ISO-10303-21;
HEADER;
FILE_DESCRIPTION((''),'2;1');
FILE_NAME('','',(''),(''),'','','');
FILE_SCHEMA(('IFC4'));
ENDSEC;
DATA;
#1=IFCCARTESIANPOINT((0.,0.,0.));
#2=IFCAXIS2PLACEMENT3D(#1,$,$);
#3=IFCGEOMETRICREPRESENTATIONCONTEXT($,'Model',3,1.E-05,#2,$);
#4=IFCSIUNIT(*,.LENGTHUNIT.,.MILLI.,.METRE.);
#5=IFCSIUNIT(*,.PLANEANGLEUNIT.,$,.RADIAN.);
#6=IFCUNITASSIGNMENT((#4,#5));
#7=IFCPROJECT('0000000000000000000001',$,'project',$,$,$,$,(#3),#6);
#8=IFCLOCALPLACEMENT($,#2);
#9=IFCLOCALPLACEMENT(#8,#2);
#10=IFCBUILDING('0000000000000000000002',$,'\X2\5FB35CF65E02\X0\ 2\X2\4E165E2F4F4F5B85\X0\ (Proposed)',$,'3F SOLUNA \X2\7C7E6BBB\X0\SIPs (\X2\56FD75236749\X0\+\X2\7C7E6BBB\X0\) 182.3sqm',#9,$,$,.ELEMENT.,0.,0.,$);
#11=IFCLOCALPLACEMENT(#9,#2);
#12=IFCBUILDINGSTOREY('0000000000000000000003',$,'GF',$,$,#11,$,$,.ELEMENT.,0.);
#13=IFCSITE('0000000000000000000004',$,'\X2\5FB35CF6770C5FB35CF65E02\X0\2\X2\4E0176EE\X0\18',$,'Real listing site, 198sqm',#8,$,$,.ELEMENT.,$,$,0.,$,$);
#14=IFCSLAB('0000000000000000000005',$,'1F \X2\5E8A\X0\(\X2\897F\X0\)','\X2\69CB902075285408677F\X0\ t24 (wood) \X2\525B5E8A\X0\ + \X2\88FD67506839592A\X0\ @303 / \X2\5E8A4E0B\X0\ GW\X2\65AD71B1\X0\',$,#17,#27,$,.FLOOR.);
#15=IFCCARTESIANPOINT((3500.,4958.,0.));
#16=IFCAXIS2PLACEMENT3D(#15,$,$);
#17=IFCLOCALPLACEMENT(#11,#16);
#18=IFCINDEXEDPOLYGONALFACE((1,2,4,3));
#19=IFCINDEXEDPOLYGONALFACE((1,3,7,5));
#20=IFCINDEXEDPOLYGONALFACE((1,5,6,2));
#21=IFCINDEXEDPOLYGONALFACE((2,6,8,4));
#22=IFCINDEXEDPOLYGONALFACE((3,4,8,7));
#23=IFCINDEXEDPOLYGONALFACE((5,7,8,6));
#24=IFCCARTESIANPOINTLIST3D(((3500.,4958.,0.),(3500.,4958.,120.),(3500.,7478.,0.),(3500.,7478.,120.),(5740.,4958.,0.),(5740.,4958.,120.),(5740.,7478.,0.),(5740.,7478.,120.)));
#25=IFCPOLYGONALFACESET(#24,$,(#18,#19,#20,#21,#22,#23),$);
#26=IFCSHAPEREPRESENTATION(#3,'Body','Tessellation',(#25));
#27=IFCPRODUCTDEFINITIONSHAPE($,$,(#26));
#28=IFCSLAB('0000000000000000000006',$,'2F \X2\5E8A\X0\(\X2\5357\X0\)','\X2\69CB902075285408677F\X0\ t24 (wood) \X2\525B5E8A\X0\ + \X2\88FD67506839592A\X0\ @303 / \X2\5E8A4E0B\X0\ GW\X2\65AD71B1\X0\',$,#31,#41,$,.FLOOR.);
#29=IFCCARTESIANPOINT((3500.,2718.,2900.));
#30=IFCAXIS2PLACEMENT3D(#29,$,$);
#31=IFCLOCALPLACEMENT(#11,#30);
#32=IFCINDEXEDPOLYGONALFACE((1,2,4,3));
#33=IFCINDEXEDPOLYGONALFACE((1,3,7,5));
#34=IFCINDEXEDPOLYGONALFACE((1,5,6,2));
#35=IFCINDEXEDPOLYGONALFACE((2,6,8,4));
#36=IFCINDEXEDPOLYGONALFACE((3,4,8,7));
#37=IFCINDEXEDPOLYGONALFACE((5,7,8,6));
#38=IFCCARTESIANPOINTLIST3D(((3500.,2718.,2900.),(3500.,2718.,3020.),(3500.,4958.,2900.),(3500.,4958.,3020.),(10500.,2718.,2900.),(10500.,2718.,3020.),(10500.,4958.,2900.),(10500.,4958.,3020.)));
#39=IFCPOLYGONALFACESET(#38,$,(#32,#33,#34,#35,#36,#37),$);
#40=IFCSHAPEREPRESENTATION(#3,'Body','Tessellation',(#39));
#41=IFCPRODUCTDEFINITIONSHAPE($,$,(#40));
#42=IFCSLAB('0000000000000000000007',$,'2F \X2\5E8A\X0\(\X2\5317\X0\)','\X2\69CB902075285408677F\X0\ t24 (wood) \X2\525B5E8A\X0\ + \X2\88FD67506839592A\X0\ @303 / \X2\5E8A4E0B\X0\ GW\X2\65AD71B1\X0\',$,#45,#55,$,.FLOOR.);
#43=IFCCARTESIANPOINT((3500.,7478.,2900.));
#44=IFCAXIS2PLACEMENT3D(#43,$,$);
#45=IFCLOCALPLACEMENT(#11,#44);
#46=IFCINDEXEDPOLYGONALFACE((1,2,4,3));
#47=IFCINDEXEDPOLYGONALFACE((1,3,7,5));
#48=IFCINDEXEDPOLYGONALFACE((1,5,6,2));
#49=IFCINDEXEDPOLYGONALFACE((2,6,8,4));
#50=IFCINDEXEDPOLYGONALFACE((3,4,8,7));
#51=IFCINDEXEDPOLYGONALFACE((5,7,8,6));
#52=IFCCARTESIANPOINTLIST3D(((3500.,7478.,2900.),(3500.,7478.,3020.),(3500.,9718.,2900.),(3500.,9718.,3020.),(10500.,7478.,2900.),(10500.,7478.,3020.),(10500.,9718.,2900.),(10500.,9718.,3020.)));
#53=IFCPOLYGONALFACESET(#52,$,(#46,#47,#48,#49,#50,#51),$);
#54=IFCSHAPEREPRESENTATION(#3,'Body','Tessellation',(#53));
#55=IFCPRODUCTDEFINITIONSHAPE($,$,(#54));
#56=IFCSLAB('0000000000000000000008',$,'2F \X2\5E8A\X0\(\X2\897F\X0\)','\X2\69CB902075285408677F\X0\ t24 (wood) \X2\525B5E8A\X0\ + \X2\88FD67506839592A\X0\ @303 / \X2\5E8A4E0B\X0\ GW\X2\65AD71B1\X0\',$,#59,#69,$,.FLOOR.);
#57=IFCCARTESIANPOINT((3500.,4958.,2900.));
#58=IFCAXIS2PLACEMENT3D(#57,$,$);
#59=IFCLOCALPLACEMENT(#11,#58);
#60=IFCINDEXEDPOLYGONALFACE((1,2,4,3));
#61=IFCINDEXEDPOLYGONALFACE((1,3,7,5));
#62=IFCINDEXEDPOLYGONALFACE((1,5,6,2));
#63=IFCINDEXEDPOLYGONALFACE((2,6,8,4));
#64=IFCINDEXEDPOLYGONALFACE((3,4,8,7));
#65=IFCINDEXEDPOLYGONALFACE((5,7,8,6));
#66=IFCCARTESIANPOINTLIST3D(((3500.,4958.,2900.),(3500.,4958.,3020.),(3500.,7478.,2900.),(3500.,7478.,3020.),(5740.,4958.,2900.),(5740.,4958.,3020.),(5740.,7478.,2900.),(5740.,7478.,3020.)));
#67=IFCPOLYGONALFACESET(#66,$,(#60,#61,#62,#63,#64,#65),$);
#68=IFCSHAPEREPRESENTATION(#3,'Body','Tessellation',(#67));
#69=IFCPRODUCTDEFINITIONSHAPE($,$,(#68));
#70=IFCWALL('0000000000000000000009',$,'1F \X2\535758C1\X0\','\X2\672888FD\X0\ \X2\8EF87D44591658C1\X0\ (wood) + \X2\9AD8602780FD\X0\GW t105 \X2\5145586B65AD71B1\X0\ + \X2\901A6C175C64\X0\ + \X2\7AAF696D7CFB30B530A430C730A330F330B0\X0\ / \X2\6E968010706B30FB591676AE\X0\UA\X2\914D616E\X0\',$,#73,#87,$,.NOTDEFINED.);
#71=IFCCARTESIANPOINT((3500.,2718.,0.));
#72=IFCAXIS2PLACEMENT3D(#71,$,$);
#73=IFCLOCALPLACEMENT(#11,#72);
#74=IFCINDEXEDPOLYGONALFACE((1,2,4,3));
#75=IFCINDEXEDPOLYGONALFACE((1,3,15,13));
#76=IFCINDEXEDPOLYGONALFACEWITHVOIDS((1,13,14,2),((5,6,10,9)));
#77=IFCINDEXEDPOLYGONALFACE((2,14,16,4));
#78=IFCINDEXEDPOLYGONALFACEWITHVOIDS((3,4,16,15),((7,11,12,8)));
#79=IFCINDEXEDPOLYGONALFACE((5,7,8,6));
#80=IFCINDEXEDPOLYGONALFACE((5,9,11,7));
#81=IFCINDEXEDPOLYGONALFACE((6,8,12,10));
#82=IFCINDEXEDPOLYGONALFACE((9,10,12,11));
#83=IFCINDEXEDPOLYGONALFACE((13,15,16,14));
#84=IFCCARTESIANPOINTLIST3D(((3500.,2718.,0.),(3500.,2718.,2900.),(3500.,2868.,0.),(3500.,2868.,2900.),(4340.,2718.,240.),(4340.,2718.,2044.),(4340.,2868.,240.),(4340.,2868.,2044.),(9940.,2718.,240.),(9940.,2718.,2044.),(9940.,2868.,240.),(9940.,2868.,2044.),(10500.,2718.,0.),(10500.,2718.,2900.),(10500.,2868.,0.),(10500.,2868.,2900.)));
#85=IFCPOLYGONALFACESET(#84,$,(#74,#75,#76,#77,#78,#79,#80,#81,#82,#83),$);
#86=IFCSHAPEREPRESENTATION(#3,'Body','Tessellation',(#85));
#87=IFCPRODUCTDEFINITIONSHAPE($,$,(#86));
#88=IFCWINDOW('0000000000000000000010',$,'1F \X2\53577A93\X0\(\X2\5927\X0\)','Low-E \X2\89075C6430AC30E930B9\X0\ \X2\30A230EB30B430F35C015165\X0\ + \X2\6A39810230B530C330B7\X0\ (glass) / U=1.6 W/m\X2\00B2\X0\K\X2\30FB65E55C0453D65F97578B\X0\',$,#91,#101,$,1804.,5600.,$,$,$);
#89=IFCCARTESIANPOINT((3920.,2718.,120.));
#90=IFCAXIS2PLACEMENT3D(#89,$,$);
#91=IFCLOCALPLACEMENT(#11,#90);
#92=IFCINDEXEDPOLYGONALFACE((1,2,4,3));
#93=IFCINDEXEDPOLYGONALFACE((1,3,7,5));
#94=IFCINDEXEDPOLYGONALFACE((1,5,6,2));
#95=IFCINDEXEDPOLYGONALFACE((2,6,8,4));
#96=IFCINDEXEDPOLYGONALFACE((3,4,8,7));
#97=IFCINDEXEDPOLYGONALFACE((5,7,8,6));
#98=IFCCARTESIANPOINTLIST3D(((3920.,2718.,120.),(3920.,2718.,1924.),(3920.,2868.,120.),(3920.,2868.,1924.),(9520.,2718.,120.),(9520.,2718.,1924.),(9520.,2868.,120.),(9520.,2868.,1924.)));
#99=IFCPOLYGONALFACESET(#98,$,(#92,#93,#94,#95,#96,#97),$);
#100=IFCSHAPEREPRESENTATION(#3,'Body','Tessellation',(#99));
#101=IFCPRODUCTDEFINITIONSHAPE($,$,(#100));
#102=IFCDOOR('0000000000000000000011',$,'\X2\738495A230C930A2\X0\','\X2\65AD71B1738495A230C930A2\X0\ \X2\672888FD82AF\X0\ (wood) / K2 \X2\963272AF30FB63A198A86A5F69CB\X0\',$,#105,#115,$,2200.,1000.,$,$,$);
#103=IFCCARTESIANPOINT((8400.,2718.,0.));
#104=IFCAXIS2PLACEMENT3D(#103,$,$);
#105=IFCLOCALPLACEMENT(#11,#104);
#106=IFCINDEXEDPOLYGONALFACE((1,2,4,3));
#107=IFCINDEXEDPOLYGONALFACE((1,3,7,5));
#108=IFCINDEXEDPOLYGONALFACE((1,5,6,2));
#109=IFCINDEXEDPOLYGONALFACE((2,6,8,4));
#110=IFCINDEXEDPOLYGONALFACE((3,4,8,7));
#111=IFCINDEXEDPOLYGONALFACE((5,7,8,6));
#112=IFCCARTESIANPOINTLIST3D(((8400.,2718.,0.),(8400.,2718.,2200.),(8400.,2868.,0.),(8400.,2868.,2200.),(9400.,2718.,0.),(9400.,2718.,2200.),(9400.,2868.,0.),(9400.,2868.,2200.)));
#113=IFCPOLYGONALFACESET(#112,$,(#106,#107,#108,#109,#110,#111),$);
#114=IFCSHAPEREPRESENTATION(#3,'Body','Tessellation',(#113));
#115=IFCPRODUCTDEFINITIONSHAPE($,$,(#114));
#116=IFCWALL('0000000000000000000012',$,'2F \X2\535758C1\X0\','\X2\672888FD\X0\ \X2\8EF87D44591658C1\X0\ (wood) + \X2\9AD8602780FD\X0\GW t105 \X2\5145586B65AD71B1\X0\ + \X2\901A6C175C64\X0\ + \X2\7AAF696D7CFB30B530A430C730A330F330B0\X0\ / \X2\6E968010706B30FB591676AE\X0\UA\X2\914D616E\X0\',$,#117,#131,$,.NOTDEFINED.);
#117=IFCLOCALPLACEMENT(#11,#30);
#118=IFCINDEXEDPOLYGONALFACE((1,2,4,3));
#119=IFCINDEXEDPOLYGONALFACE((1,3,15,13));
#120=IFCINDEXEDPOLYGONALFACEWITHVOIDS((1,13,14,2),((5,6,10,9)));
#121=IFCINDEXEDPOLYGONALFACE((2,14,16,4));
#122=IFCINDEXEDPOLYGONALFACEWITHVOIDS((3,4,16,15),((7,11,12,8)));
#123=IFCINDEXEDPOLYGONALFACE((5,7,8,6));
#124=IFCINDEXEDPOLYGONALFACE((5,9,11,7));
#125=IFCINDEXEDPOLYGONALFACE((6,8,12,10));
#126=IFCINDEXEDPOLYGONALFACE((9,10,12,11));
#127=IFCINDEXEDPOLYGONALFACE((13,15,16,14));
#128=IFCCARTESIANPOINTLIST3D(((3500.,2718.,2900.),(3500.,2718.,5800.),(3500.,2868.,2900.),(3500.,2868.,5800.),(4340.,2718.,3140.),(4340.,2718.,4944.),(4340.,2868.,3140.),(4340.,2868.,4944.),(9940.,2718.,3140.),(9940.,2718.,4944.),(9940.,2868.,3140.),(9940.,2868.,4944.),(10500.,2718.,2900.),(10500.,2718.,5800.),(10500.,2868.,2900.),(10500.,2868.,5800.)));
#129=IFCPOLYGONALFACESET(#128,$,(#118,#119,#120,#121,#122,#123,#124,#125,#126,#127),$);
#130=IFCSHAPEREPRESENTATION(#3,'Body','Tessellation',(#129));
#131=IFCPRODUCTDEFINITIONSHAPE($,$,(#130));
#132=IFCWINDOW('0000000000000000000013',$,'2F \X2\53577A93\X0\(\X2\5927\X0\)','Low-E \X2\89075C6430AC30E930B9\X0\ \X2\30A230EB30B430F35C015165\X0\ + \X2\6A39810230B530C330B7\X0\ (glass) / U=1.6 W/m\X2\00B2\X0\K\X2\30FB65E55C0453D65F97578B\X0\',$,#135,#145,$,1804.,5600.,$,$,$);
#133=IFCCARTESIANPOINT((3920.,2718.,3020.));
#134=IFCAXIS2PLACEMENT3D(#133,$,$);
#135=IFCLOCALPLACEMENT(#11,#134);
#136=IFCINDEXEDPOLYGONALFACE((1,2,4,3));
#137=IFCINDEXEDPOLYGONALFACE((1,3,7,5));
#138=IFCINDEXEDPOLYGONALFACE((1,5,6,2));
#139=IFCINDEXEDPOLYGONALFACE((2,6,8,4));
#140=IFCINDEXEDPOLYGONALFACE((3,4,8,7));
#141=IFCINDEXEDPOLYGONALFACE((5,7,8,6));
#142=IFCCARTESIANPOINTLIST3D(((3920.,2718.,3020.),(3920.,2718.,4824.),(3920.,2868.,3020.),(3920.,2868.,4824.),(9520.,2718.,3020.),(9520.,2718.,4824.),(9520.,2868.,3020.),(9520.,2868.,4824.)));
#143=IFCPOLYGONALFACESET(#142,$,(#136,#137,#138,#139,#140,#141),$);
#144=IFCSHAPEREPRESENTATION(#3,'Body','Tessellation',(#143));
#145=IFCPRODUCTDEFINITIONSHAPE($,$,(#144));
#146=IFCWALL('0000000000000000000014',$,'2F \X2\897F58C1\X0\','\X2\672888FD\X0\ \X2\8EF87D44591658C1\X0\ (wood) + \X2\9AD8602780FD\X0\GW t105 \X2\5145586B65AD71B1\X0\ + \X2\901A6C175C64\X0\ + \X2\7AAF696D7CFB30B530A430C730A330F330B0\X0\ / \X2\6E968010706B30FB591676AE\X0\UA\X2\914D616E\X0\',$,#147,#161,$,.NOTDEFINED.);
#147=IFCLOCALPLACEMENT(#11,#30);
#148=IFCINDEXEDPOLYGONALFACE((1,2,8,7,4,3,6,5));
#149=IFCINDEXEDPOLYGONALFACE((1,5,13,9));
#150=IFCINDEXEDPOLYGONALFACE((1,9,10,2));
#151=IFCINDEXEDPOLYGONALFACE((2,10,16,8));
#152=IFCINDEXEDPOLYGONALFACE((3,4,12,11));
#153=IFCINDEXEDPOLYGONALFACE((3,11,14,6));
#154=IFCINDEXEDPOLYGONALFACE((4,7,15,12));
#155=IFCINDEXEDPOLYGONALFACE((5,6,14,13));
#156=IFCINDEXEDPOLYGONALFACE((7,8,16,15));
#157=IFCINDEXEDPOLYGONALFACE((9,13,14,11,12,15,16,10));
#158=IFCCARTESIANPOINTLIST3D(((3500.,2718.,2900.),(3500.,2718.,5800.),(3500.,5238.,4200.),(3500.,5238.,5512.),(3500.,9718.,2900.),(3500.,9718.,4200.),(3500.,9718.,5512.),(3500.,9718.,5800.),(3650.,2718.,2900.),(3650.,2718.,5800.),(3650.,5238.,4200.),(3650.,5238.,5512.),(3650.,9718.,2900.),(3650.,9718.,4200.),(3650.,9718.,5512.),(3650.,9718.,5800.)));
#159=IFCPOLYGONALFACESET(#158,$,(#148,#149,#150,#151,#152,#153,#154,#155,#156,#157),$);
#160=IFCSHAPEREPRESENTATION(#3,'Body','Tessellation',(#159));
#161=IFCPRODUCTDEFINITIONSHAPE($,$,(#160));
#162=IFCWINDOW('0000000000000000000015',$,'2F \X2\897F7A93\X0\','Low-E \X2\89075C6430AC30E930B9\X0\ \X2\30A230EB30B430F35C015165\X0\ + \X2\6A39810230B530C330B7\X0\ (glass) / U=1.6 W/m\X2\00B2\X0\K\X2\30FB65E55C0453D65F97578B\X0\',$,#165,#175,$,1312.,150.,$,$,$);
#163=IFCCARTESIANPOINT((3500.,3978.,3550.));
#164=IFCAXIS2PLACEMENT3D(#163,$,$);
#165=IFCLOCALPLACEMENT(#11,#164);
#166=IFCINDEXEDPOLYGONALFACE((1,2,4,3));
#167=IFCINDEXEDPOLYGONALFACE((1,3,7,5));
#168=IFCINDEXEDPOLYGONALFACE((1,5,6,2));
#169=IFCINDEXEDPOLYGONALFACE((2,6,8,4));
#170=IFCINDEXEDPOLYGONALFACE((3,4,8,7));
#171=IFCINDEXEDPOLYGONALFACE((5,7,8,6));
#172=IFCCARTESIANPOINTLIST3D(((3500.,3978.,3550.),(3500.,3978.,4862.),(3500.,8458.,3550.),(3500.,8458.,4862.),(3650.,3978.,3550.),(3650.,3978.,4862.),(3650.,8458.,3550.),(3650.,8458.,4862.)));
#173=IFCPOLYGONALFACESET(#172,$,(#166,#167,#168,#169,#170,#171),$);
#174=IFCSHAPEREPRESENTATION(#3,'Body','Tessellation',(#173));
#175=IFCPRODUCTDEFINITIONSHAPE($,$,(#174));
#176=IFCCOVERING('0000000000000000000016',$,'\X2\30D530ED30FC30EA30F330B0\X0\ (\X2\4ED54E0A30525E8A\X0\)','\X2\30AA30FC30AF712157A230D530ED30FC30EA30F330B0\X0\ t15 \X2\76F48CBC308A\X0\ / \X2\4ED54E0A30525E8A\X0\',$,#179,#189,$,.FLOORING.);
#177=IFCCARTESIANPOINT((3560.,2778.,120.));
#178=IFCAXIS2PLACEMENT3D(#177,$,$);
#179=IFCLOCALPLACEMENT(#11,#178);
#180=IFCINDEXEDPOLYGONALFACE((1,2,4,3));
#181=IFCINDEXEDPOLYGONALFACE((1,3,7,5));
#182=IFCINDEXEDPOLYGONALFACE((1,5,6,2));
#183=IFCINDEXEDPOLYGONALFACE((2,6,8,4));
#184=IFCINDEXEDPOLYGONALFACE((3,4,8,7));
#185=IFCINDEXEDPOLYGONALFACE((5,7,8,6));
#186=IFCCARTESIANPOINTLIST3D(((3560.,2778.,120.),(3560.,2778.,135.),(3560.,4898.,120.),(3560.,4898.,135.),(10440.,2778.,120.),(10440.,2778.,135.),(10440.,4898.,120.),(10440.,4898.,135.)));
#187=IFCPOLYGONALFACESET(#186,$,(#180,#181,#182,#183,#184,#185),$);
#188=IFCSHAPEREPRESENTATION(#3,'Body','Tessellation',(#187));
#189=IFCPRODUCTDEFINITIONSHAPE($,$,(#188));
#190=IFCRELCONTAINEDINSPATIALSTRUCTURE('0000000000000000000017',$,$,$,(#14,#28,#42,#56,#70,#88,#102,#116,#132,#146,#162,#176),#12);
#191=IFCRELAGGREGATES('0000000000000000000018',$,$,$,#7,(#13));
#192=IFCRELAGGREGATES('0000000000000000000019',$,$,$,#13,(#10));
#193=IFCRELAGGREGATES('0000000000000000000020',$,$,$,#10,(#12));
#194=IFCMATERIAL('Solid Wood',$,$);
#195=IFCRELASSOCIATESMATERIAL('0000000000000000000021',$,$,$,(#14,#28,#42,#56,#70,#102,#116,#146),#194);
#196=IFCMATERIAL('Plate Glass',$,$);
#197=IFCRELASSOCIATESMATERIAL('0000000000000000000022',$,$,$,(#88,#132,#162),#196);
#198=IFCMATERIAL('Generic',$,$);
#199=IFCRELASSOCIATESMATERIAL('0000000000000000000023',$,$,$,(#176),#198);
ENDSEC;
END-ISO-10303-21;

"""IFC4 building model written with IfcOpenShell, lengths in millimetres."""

from ifc_helpers import new_model, si_unit, frame, frame_2d, origin, place, context, project, spatial, rectangle, extrude, material, element, fill, save


model = new_model("IFC4")

# Units and contexts
model_context = context("Model", 3, precision=1e-05, world=origin())
ifc_project = project(units=[si_unit("LENGTHUNIT", "METRE", prefix="MILLI"), si_unit("PLANEANGLEUNIT", "RADIAN")], contexts=[model_context])

# Site, building, storey
site_placement = place(None, origin())
site = spatial("IfcSite", under=ifc_project, at=site_placement, Name="徳島県徳島市2丁目18", ObjectType="Real listing site, 198sqm", CompositionType="ELEMENT", RefElevation=0.0)
building_placement = place(site_placement, origin())
building = spatial("IfcBuilding", under=site, at=building_placement, Name="徳島市 2世帯住宅 (Proposed)", ObjectType="3F SOLUNA 籾殻SIPs (国産杉+籾殻) 182.3sqm", CompositionType="ELEMENT", ElevationOfRefHeight=0.0, ElevationOfTerrain=0.0)
storey_placement = place(building_placement, origin())
storey = spatial("IfcBuildingStorey", under=building, at=storey_placement, Name="GF", CompositionType="ELEMENT", Elevation=0.0)

# Slabs
ifc_material_1 = material(Name="Solid Wood")
slab_1_placement = place(storey_placement, frame((3500.0, 4958.0, 0.0)))
element("IfcSlab", 1, at=slab_1_placement, inside=storey, material=ifc_material_1, Name="1F 床(西)", Description="構造用合板 t24 (wood) 剛床 + 製材根太 @303 / 床下 GW断熱", PredefinedType="FLOOR", context=model_context, shape_type="SweptSolid", body=[
    extrude(rectangle(XDim=2240.0, YDim=2520.0, at=frame_2d((1120.0, 1260.0))), frame((3500.0, 4958.0, 0.0)), (0.0, 0.0, 1.0), 120.0),
])
slab_2_placement = place(storey_placement, frame((3500.0, 2718.0, 2900.0)))
element("IfcSlab", 2, at=slab_2_placement, inside=storey, material=ifc_material_1, Name="2F 床(南)", Description="構造用合板 t24 (wood) 剛床 + 製材根太 @303 / 床下 GW断熱", PredefinedType="FLOOR", context=model_context, shape_type="SweptSolid", body=[
    extrude(rectangle(XDim=7000.0, YDim=2240.0, at=frame_2d((3500.0, 1120.0))), frame((3500.0, 2718.0, 2900.0)), (0.0, 0.0, 1.0), 120.0),
])
slab_3_placement = place(storey_placement, frame((3500.0, 7478.0, 2900.0)))
element("IfcSlab", 3, at=slab_3_placement, inside=storey, material=ifc_material_1, Name="2F 床(北)", Description="構造用合板 t24 (wood) 剛床 + 製材根太 @303 / 床下 GW断熱", PredefinedType="FLOOR", context=model_context, shape_type="SweptSolid", body=[
    extrude(rectangle(XDim=7000.0, YDim=2240.0, at=frame_2d((3500.0, 1120.0))), frame((3500.0, 7478.0, 2900.0)), (0.0, 0.0, 1.0), 120.0),
])
slab_4_placement = place(storey_placement, frame((3500.0, 4958.0, 2900.0)))
element("IfcSlab", 4, at=slab_4_placement, inside=storey, material=ifc_material_1, Name="2F 床(西)", Description="構造用合板 t24 (wood) 剛床 + 製材根太 @303 / 床下 GW断熱", PredefinedType="FLOOR", context=model_context, shape_type="SweptSolid", body=[
    extrude(rectangle(XDim=2240.0, YDim=2520.0, at=frame_2d((1120.0, 1260.0))), frame((3500.0, 4958.0, 2900.0)), (0.0, 0.0, 1.0), 120.0),
])

# Wall, openings, window, door
wall_1_placement = place(storey_placement, frame((3500.0, 2718.0, 0.0)))
wall_1 = element("IfcWall", 5, at=wall_1_placement, inside=storey, material=ifc_material_1, Name="1F 南壁", Description="木製 軸組外壁 (wood) + 高性能GW t105 充填断熱 + 通気層 + 窯業系サイディング / 準耐火・外皮UA配慮", PredefinedType="NOTDEFINED", context=model_context, shape_type="SweptSolid", body=[
    extrude(rectangle(XDim=7000.0, YDim=150.0, at=frame_2d((3500.0, 75.0))), frame((3500.0, 2718.0, 0.0)), (0.0, 0.0, 1.0), 2900.0),
])
opening_1_placement = place(storey_placement, frame((3920.0, 2718.0, 120.0)))
opening_1 = element("IfcOpeningElement", 6, at=opening_1_placement, cuts=wall_1, PredefinedType="NOTDEFINED", context=model_context, shape_type="SweptSolid", body=[
    extrude(rectangle(XDim=5600.0, YDim=150.0, at=frame_2d((2800.0, 75.0))), frame((3920.0, 2718.0, 120.0)), (0.0, 0.0, 1.0), 1804.0),
])
opening_2_placement = place(storey_placement, frame((8400.0, 2718.0, 0.0)))
opening_2 = element("IfcOpeningElement", 7, at=opening_2_placement, cuts=wall_1, PredefinedType="NOTDEFINED", context=model_context, shape_type="SweptSolid", body=[
    extrude(rectangle(XDim=1000.0, YDim=150.0, at=frame_2d((500.0, 75.0))), frame((8400.0, 2718.0, 0.0)), (0.0, 0.0, 1.0), 2200.0),
])
ifc_material_2 = material(Name="Plate Glass")
window_1_placement = place(storey_placement, frame((3920.0, 2718.0, 120.0)))
window_1 = element("IfcWindow", 8, at=window_1_placement, inside=storey, material=ifc_material_2, Name="1F 南窓(大)", Description="Low-E 複層ガラス アルゴン封入 + 樹脂サッシ (glass) / U=1.6 W/m²K・日射取得型", OverallHeight=1804.0, OverallWidth=5600.0, context=model_context, shape_type="SweptSolid", body=[
    extrude(rectangle(XDim=5600.0, YDim=150.0, at=frame_2d((2800.0, 75.0))), frame((3920.0, 2718.0, 120.0)), (0.0, 0.0, 1.0), 1804.0),
])
fill(opening_1, window_1)
door_placement = place(storey_placement, frame((8400.0, 2718.0, 0.0)))
door = element("IfcDoor", 9, at=door_placement, inside=storey, material=ifc_material_1, Name="玄関ドア", Description="断熱玄関ドア 木製芯 (wood) / K2 防犯・採風機構", OverallHeight=2200.0, OverallWidth=1000.0, context=model_context, shape_type="SweptSolid", body=[
    extrude(rectangle(XDim=1000.0, YDim=150.0, at=frame_2d((500.0, 75.0))), frame((8400.0, 2718.0, 0.0)), (0.0, 0.0, 1.0), 2200.0),
])
fill(opening_2, door)

# Wall, opening, window
wall_2_placement = place(storey_placement, frame((3500.0, 2718.0, 2900.0)))
wall_2 = element("IfcWall", 10, at=wall_2_placement, inside=storey, material=ifc_material_1, Name="2F 南壁", Description="木製 軸組外壁 (wood) + 高性能GW t105 充填断熱 + 通気層 + 窯業系サイディング / 準耐火・外皮UA配慮", PredefinedType="NOTDEFINED", context=model_context, shape_type="SweptSolid", body=[
    extrude(rectangle(XDim=7000.0, YDim=150.0, at=frame_2d((3500.0, 75.0))), frame((3500.0, 2718.0, 2900.0)), (0.0, 0.0, 1.0), 2900.0),
])
opening_3_placement = place(storey_placement, frame((3920.0, 2718.0, 3020.0)))
opening_3 = element("IfcOpeningElement", 11, at=opening_3_placement, cuts=wall_2, PredefinedType="NOTDEFINED", context=model_context, shape_type="SweptSolid", body=[
    extrude(rectangle(XDim=5600.0, YDim=150.0, at=frame_2d((2800.0, 75.0))), frame((3920.0, 2718.0, 3020.0)), (0.0, 0.0, 1.0), 1804.0),
])
window_2_placement = place(storey_placement, frame((3920.0, 2718.0, 3020.0)))
window_2 = element("IfcWindow", 12, at=window_2_placement, inside=storey, material=ifc_material_2, Name="2F 南窓(大)", Description="Low-E 複層ガラス アルゴン封入 + 樹脂サッシ (glass) / U=1.6 W/m²K・日射取得型", OverallHeight=1804.0, OverallWidth=5600.0, context=model_context, shape_type="SweptSolid", body=[
    extrude(rectangle(XDim=5600.0, YDim=150.0, at=frame_2d((2800.0, 75.0))), frame((3920.0, 2718.0, 3020.0)), (0.0, 0.0, 1.0), 1804.0),
])
fill(opening_3, window_2)

# Wall, opening, window
wall_3_placement = place(storey_placement, frame((3500.0, 2718.0, 2900.0)))
wall_3 = element("IfcWall", 13, at=wall_3_placement, inside=storey, material=ifc_material_1, Name="2F 西壁", Description="木製 軸組外壁 (wood) + 高性能GW t105 充填断熱 + 通気層 + 窯業系サイディング / 準耐火・外皮UA配慮", PredefinedType="NOTDEFINED", context=model_context, shape_type="SweptSolid", body=[
    extrude(rectangle(XDim=150.0, YDim=7000.0, at=frame_2d((75.0, 3500.0))), frame((3500.0, 2718.0, 2900.0)), (0.0, 0.0, 1.0), 2900.0),
])
opening_4_placement = place(storey_placement, frame((3500.0, 3978.0, 3550.0)))
opening_4 = element("IfcOpeningElement", 14, at=opening_4_placement, cuts=wall_3, PredefinedType="NOTDEFINED", context=model_context, shape_type="SweptSolid", body=[
    extrude(rectangle(XDim=150.0, YDim=4480.0, at=frame_2d((75.0, 2240.0))), frame((3500.0, 3978.0, 3550.0)), (0.0, 0.0, 1.0), 1312.0),
])
window_3_placement = place(storey_placement, frame((3500.0, 3978.0, 3550.0)))
window_3 = element("IfcWindow", 15, at=window_3_placement, inside=storey, material=ifc_material_2, Name="2F 西窓", Description="Low-E 複層ガラス アルゴン封入 + 樹脂サッシ (glass) / U=1.6 W/m²K・日射取得型", OverallHeight=1312.0, OverallWidth=150.0, context=model_context, shape_type="SweptSolid", body=[
    extrude(rectangle(XDim=150.0, YDim=4480.0, at=frame_2d((75.0, 2240.0))), frame((3500.0, 3978.0, 3550.0)), (0.0, 0.0, 1.0), 1312.0),
])
fill(opening_4, window_3)

# Covering
ifc_material_3 = material(Name="Generic")
covering_1_placement = place(storey_placement, frame((3560.0, 2778.0, 120.0)))
element("IfcCovering", 16, at=covering_1_placement, inside=storey, material=ifc_material_3, Name="フローリング (仕上げ床)", Description="オーク無垢フローリング t15 直貼り / 仕上げ床", PredefinedType="FLOORING", context=model_context, shape_type="SweptSolid", body=[
    extrude(rectangle(XDim=6880.0, YDim=2120.0, at=frame_2d((3440.0, 1060.0))), frame((3560.0, 2778.0, 120.0)), (0.0, 0.0, 1.0), 15.0),
])

save(model, "model.ifc")
